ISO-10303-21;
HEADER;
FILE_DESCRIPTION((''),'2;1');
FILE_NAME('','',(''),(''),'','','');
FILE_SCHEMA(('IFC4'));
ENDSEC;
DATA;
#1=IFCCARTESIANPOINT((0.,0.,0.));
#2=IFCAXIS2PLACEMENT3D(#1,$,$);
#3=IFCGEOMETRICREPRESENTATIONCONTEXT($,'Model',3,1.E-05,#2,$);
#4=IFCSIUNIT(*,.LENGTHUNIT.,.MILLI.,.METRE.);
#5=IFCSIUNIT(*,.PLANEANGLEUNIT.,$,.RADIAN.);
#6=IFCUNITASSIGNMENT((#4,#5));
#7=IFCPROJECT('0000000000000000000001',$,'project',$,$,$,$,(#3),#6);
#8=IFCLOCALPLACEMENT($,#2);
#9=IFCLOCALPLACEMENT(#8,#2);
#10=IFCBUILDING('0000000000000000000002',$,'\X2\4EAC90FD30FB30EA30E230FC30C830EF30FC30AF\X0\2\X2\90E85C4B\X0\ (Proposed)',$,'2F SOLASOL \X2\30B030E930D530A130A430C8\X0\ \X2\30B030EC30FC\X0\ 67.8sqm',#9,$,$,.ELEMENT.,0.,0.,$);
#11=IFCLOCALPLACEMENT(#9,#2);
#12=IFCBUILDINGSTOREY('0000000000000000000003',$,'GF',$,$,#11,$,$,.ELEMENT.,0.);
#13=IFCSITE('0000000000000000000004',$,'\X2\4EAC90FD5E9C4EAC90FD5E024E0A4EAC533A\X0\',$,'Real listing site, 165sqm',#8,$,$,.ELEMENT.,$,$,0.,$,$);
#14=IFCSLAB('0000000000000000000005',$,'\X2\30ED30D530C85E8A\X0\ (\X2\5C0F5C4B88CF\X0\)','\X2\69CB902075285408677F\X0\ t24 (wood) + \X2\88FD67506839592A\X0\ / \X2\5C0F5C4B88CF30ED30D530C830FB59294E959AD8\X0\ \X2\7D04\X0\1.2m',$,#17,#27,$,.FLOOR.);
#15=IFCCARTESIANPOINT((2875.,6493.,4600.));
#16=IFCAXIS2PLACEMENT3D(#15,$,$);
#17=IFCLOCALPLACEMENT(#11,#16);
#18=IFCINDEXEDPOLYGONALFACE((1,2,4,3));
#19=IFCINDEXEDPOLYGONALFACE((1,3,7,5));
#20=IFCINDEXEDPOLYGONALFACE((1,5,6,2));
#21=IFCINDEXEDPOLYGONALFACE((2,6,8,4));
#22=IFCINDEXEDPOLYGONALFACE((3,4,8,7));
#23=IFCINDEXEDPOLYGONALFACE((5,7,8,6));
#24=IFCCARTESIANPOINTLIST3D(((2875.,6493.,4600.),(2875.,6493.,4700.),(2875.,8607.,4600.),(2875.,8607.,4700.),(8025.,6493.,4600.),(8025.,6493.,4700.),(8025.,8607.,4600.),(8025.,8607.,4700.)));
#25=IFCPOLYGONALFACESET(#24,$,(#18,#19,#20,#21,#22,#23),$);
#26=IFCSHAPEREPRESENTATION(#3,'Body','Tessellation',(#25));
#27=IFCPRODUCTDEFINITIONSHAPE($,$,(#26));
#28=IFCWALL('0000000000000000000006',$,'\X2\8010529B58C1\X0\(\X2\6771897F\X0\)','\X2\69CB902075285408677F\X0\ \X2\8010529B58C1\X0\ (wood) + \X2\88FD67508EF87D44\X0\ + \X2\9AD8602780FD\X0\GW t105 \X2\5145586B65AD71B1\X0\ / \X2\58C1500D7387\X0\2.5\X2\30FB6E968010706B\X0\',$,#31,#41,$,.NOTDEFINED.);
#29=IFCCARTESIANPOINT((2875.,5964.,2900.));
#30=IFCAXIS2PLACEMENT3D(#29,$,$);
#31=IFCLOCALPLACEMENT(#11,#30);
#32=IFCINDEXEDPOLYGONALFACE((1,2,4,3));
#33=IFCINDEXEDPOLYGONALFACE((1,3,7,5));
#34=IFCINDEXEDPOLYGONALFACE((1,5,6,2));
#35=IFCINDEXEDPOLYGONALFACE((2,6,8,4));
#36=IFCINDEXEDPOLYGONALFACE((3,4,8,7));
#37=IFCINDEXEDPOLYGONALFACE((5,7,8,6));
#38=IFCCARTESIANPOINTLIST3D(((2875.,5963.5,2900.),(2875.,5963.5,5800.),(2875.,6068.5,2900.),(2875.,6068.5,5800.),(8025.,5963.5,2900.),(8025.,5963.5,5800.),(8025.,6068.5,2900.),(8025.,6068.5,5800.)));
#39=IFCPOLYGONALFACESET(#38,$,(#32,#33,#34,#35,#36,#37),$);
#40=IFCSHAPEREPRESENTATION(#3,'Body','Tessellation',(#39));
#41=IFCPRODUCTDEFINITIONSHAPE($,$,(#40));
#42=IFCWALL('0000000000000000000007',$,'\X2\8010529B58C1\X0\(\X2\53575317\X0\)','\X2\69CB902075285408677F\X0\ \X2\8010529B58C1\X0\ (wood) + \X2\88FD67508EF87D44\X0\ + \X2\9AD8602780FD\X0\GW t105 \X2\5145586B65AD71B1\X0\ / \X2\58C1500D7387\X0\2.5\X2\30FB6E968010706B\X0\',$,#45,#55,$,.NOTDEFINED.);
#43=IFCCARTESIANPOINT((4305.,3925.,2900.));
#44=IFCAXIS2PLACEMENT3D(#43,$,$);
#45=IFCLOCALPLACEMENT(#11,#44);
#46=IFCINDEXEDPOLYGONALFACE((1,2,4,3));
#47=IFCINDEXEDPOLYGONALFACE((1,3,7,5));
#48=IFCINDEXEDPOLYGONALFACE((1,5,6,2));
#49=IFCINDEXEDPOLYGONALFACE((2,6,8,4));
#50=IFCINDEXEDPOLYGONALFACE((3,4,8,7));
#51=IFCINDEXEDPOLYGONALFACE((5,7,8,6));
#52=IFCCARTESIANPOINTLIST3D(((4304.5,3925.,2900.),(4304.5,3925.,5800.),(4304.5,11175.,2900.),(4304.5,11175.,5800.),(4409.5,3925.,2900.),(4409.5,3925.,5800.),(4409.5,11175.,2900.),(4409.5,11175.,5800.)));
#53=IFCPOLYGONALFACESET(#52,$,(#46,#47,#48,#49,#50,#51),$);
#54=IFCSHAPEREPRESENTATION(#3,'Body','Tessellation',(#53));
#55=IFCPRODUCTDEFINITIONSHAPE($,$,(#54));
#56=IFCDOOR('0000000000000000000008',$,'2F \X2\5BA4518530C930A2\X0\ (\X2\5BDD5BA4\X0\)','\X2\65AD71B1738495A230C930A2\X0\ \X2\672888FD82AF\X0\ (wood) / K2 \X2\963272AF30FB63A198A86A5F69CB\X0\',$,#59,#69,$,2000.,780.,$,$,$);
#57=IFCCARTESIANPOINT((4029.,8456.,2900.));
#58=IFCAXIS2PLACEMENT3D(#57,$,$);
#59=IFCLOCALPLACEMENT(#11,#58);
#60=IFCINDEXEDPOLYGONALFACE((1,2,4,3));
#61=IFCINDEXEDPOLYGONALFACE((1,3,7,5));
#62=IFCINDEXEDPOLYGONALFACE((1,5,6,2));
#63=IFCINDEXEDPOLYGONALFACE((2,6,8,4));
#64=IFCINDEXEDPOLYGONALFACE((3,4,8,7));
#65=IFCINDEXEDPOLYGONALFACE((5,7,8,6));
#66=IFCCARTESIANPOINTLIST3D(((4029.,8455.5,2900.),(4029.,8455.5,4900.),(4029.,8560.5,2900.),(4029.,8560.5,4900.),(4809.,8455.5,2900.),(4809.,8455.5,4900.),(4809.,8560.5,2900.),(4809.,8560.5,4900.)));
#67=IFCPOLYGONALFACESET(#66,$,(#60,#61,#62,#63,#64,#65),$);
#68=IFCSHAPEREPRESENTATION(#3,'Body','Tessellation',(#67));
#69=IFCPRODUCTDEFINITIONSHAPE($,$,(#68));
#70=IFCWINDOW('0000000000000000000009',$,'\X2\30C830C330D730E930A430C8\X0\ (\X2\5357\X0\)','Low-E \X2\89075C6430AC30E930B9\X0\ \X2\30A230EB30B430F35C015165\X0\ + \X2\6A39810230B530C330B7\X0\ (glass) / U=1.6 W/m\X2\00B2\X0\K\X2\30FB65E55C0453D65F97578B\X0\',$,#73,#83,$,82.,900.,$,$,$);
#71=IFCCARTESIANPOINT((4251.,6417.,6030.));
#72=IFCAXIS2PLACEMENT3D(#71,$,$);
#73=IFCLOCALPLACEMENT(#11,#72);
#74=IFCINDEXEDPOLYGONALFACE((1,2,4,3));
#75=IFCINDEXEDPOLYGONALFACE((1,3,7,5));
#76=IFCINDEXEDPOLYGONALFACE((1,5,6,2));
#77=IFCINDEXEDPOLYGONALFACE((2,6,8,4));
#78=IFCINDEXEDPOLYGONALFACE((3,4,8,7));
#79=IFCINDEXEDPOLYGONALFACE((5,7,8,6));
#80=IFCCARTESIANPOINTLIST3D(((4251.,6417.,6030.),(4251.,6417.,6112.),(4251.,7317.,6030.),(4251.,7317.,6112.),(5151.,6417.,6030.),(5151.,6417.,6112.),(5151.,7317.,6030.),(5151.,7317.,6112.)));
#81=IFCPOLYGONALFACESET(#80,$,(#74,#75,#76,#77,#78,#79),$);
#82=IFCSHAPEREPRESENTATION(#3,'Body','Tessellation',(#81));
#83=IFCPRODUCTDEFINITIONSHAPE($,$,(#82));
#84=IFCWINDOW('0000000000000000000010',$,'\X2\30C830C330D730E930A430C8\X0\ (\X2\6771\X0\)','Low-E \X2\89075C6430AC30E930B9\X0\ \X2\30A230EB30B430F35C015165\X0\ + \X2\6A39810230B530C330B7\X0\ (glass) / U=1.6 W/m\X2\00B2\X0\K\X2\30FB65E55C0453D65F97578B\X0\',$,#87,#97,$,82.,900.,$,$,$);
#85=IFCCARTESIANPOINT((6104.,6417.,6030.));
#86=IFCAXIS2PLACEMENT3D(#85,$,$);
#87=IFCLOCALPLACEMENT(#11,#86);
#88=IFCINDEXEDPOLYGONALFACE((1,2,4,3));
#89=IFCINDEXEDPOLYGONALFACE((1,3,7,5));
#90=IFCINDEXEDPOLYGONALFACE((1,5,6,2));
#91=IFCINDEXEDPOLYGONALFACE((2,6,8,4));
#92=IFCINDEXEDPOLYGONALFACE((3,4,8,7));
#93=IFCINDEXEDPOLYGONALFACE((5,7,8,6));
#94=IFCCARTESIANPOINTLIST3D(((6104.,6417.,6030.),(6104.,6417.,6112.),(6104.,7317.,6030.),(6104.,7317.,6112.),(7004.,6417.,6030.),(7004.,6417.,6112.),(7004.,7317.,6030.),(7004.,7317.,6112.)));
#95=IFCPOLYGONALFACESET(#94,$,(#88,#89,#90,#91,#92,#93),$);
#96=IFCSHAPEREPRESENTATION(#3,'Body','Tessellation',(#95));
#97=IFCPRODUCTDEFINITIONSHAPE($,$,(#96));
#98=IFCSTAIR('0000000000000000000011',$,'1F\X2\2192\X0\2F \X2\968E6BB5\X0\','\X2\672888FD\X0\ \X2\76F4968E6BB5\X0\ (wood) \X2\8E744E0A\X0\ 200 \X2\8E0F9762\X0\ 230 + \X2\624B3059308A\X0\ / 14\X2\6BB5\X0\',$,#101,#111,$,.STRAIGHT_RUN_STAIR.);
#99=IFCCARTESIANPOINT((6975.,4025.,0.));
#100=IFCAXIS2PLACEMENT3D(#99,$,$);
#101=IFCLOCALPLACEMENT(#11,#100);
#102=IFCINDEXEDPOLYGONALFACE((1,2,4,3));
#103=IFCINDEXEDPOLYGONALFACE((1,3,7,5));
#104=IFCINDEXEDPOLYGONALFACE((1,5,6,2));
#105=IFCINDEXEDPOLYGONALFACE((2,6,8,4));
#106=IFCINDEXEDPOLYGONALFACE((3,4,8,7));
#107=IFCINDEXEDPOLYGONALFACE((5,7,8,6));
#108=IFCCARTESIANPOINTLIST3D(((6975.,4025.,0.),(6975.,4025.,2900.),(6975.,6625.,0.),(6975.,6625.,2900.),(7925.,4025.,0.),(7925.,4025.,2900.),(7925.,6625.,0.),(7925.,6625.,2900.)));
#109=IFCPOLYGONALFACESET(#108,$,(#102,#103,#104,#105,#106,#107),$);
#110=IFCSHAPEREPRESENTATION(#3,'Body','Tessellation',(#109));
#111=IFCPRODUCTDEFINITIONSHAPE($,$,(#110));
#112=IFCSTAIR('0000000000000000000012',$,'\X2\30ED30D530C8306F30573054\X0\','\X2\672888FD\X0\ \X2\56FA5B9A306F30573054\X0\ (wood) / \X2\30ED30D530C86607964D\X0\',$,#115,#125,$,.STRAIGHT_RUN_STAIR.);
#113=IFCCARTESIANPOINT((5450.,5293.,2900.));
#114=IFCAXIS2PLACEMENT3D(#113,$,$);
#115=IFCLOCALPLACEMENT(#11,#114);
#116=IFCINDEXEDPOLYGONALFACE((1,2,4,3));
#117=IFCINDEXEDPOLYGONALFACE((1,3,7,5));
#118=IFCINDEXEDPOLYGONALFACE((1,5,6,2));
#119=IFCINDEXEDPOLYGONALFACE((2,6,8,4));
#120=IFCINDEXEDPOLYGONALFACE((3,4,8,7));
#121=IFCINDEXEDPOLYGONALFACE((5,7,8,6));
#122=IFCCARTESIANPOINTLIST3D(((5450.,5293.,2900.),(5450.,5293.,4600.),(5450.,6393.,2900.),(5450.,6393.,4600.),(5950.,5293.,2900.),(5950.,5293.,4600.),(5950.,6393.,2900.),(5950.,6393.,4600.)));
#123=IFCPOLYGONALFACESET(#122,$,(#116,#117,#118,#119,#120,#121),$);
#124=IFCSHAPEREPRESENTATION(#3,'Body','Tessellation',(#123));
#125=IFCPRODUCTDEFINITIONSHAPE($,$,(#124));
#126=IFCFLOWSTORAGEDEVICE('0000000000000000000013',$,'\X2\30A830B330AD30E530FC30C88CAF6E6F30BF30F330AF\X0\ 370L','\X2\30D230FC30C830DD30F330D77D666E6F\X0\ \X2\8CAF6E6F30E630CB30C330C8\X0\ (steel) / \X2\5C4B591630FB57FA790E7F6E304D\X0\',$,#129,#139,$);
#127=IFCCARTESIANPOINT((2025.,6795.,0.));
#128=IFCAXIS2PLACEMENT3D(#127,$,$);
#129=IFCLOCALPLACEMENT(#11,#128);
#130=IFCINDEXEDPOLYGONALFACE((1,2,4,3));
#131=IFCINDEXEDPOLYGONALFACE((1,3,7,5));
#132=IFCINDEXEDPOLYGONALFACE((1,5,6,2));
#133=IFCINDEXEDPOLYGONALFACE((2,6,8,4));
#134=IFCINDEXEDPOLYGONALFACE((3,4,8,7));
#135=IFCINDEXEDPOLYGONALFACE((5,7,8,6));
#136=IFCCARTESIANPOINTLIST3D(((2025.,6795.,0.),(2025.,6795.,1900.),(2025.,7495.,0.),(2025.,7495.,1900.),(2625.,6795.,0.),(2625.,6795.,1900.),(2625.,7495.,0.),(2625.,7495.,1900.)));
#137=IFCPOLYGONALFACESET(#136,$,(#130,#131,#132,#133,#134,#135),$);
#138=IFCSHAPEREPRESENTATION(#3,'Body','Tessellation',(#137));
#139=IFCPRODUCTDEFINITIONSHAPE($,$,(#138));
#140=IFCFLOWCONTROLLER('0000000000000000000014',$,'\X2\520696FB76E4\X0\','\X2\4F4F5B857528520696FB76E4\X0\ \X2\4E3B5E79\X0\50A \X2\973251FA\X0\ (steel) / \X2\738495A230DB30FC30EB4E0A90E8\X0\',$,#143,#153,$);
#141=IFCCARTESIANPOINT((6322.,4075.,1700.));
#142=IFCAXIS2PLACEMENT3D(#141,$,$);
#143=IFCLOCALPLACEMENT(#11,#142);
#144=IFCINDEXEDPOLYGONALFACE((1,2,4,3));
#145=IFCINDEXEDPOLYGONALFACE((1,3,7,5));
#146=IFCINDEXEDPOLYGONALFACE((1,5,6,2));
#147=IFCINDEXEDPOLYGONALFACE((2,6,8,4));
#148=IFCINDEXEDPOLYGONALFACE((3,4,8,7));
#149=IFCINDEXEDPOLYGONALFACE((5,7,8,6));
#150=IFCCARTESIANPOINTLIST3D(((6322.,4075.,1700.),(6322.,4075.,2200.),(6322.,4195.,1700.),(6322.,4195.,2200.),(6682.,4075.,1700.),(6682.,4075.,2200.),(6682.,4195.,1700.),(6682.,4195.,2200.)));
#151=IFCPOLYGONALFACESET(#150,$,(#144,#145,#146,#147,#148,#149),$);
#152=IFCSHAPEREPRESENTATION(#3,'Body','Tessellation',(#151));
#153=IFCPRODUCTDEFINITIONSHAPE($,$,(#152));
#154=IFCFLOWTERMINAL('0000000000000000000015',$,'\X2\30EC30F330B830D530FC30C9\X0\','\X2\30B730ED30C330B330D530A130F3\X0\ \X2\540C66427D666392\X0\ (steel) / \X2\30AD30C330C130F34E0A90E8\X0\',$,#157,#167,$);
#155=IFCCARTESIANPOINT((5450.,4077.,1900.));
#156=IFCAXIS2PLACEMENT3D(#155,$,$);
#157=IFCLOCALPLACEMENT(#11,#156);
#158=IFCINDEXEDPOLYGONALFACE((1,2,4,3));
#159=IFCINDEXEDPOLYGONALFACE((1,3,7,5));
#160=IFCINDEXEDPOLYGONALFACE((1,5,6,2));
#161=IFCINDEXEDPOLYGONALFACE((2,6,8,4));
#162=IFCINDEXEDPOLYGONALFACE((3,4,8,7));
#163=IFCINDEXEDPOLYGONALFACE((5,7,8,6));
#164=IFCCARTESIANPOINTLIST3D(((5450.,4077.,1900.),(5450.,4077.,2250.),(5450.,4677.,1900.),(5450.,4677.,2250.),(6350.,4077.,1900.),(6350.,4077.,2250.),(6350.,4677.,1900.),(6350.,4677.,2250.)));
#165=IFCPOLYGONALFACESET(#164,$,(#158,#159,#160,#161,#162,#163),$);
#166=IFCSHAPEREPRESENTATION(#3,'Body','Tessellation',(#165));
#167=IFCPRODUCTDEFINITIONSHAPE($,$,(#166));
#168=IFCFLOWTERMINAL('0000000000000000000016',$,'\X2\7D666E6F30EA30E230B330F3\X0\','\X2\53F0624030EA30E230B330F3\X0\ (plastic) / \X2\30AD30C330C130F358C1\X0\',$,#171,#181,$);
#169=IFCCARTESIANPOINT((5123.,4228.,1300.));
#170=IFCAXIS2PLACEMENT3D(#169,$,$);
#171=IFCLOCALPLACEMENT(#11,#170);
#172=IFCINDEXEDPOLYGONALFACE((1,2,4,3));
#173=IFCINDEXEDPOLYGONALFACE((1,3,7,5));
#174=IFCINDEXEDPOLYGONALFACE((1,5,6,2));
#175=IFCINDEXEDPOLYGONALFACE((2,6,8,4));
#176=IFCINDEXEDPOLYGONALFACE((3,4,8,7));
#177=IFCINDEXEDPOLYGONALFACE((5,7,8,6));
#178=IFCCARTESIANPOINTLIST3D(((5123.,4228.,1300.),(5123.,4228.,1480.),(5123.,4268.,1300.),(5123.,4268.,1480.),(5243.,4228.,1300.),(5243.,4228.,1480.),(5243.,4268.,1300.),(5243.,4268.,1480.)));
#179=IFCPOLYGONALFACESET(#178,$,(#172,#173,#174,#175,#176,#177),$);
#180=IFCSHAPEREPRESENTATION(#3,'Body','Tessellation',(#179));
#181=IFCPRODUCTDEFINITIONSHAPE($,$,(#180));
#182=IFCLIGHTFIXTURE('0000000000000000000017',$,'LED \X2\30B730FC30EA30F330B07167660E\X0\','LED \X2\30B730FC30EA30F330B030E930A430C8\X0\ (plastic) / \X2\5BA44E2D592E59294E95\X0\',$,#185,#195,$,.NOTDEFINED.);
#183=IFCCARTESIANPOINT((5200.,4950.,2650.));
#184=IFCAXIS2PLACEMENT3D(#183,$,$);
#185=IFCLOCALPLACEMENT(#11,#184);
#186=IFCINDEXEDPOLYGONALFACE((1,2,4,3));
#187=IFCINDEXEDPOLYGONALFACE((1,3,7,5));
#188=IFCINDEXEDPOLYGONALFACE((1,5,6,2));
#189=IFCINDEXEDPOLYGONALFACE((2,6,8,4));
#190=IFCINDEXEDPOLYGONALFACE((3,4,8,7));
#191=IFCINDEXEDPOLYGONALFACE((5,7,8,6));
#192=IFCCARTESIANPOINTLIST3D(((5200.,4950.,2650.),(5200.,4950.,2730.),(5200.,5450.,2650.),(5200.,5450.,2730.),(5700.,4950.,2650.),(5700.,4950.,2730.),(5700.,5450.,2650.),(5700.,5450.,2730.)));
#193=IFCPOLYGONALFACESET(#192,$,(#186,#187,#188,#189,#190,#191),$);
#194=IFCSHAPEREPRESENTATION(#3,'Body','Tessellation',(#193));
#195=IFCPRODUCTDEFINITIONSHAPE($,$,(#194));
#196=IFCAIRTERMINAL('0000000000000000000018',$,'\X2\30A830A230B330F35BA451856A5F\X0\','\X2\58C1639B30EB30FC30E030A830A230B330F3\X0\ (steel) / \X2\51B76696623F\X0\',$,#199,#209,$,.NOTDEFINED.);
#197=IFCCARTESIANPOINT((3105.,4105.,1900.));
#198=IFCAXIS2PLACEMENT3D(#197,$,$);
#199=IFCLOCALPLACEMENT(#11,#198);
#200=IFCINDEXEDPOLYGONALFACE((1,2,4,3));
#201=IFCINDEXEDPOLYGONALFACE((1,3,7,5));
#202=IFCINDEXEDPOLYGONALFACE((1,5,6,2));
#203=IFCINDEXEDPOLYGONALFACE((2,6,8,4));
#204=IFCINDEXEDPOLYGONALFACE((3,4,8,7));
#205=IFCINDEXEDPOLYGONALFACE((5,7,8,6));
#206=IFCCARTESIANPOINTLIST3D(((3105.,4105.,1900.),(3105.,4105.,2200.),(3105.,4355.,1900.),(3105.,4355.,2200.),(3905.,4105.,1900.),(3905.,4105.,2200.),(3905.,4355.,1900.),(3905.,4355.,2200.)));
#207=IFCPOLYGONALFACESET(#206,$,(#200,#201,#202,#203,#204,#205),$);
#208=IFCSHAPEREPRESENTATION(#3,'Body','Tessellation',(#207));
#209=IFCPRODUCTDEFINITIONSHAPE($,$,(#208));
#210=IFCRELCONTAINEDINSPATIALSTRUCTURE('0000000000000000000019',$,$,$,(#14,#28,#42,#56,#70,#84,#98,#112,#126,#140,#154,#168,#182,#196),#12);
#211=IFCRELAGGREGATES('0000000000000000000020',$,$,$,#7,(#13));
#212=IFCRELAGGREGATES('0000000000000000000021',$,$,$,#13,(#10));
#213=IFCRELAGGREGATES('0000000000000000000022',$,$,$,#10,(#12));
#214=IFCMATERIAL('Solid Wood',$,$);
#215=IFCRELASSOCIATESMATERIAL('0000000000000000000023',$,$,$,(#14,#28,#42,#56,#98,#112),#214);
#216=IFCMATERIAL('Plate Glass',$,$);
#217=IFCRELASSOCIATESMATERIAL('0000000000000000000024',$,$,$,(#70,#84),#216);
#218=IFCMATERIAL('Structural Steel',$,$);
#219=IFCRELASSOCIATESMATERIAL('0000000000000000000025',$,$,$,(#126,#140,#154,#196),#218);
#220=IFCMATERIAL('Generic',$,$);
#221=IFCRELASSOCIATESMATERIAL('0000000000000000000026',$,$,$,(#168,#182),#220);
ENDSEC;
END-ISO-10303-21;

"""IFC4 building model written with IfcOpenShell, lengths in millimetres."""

from ifc_helpers import new_model, si_unit, frame, frame_2d, origin, place, context, project, spatial, rectangle, extrude, material, element, fill, save


model = new_model("IFC4")

# Units and contexts
model_context = context("Model", 3, precision=1e-05, world=origin())
ifc_project = project(units=[si_unit("LENGTHUNIT", "METRE", prefix="MILLI"), si_unit("PLANEANGLEUNIT", "RADIAN")], contexts=[model_context])

# Site, building, storey
site_placement = place(None, origin())
site = spatial("IfcSite", under=ifc_project, at=site_placement, Name="京都府京都市上京区", ObjectType="Real listing site, 165sqm", CompositionType="ELEMENT", RefElevation=0.0)
building_placement = place(site_placement, origin())
building = spatial("IfcBuilding", under=site, at=building_placement, Name="京都・リモートワーク2部屋 (Proposed)", ObjectType="2F SOLASOL グラファイト グレー 67.8sqm", CompositionType="ELEMENT", ElevationOfRefHeight=0.0, ElevationOfTerrain=0.0)
storey_placement = place(building_placement, origin())
storey = spatial("IfcBuildingStorey", under=building, at=storey_placement, Name="GF", CompositionType="ELEMENT", Elevation=0.0)

# Shared definitions
ifc_material_1 = material(Name="Solid Wood")

# Slab
slab_placement = place(storey_placement, frame((2875.0, 6493.0, 4600.0)))
element("IfcSlab", 1, at=slab_placement, inside=storey, material=ifc_material_1, Name="ロフト床 (小屋裏)", Description="構造用合板 t24 (wood) + 製材根太 / 小屋裏ロフト・天井高 約1.2m", PredefinedType="FLOOR", context=model_context, shape_type="SweptSolid", body=[
    extrude(rectangle(XDim=5150.0, YDim=2114.0, at=frame_2d((2575.0, 1057.0))), frame((2875.0, 6493.0, 4600.0)), (0.0, 0.0, 1.0), 100.0),
])

# Wall
wall_1_placement = place(storey_placement, frame((2875.0, 5964.0, 2900.0)))
element("IfcWall", 2, at=wall_1_placement, inside=storey, material=ifc_material_1, Name="耐力壁(東西)", Description="構造用合板 耐力壁 (wood) + 製材軸組 + 高性能GW t105 充填断熱 / 壁倍率2.5・準耐火", PredefinedType="NOTDEFINED", context=model_context, shape_type="SweptSolid", body=[
    extrude(rectangle(XDim=5150.0, YDim=105.0, at=frame_2d((2575.0, 52.0))), frame((2875.0, 5964.0, 2900.0)), (0.0, 0.0, 1.0), 2900.0),
])

# Wall, opening, door
wall_2_placement = place(storey_placement, frame((4305.0, 3925.0, 2900.0)))
wall_2 = element("IfcWall", 3, at=wall_2_placement, inside=storey, material=ifc_material_1, Name="耐力壁(南北)", Description="構造用合板 耐力壁 (wood) + 製材軸組 + 高性能GW t105 充填断熱 / 壁倍率2.5・準耐火", PredefinedType="NOTDEFINED", context=model_context, shape_type="SweptSolid", body=[
    extrude(rectangle(XDim=105.0, YDim=7250.0, at=frame_2d((52.0, 3625.0))), frame((4305.0, 3925.0, 2900.0)), (0.0, 0.0, 1.0), 2900.0),
])
opening_placement = place(storey_placement, frame((4029.0, 8456.0, 2900.0)))
opening = element("IfcOpeningElement", 4, at=opening_placement, cuts=wall_2, PredefinedType="NOTDEFINED", context=model_context, shape_type="SweptSolid", body=[
    extrude(rectangle(XDim=780.0, YDim=105.0, at=frame_2d((390.0, 52.0))), frame((4029.0, 8456.0, 2900.0)), (0.0, 0.0, 1.0), 2000.0),
])
door_placement = place(storey_placement, frame((4029.0, 8456.0, 2900.0)))
door = element("IfcDoor", 5, at=door_placement, inside=storey, material=ifc_material_1, Name="2F 室内ドア (寝室)", Description="断熱玄関ドア 木製芯 (wood) / K2 防犯・採風機構", OverallHeight=2000.0, OverallWidth=780.0, context=model_context, shape_type="SweptSolid", body=[
    extrude(rectangle(XDim=780.0, YDim=105.0, at=frame_2d((390.0, 52.0))), frame((4029.0, 8456.0, 2900.0)), (0.0, 0.0, 1.0), 2000.0),
])
fill(opening, door)

# Windows
ifc_material_2 = material(Name="Plate Glass")
window_1_placement = place(storey_placement, frame((4251.0, 6417.0, 6030.0)))
element("IfcWindow", 6, at=window_1_placement, inside=storey, material=ifc_material_2, Name="トップライト (南)", Description="Low-E 複層ガラス アルゴン封入 + 樹脂サッシ (glass) / U=1.6 W/m²K・日射取得型", OverallHeight=82.0, OverallWidth=900.0, context=model_context, shape_type="SweptSolid", body=[
    extrude(rectangle(XDim=900.0, YDim=900.0, at=frame_2d((450.0, 450.0))), frame((4251.0, 6417.0, 6030.0)), (0.0, 0.0, 1.0), 82.0),
])
window_2_placement = place(storey_placement, frame((6104.0, 6417.0, 6030.0)))
element("IfcWindow", 7, at=window_2_placement, inside=storey, material=ifc_material_2, Name="トップライト (東)", Description="Low-E 複層ガラス アルゴン封入 + 樹脂サッシ (glass) / U=1.6 W/m²K・日射取得型", OverallHeight=82.0, OverallWidth=900.0, context=model_context, shape_type="SweptSolid", body=[
    extrude(rectangle(XDim=900.0, YDim=900.0, at=frame_2d((450.0, 450.0))), frame((6104.0, 6417.0, 6030.0)), (0.0, 0.0, 1.0), 82.0),
])

# Stairs
stair_1_placement = place(storey_placement, frame((6975.0, 4025.0, 0.0)))
element("IfcStair", 8, at=stair_1_placement, inside=storey, material=ifc_material_1, Name="1F→2F 階段", Description="木製 直階段 (wood) 蹴上 200 踏面 230 + 手すり / 14段", PredefinedType="STRAIGHT_RUN_STAIR", context=model_context, shape_type="SweptSolid", body=[
    extrude(rectangle(XDim=950.0, YDim=2600.0, at=frame_2d((475.0, 1300.0))), frame((6975.0, 4025.0, 0.0)), (0.0, 0.0, 1.0), 2900.0),
])
stair_2_placement = place(storey_placement, frame((5450.0, 5293.0, 2900.0)))
element("IfcStair", 9, at=stair_2_placement, inside=storey, material=ifc_material_1, Name="ロフトはしご", Description="木製 固定はしご (wood) / ロフト昇降", PredefinedType="STRAIGHT_RUN_STAIR", context=model_context, shape_type="SweptSolid", body=[
    extrude(rectangle(XDim=500.0, YDim=1100.0, at=frame_2d((250.0, 550.0))), frame((5450.0, 5293.0, 2900.0)), (0.0, 0.0, 1.0), 1700.0),
])

# Flow storage device
ifc_material_3 = material(Name="Structural Steel")
flow_storage_device_placement = place(storey_placement, frame((2025.0, 6795.0, 0.0)))
element("IfcFlowStorageDevice", 10, at=flow_storage_device_placement, inside=storey, material=ifc_material_3, Name="エコキュート貯湯タンク 370L", Description="ヒートポンプ給湯 貯湯ユニット (steel) / 屋外・基礎置き", context=model_context, shape_type="SweptSolid", body=[
    extrude(rectangle(XDim=600.0, YDim=700.0, at=frame_2d((300.0, 350.0))), frame((2025.0, 6795.0, 0.0)), (0.0, 0.0, 1.0), 1900.0),
])

# Flow controller
flow_controller_placement = place(storey_placement, frame((6322.0, 4075.0, 1700.0)))
element("IfcFlowController", 11, at=flow_controller_placement, inside=storey, material=ifc_material_3, Name="分電盤", Description="住宅用分電盤 主幹50A 露出 (steel) / 玄関ホール上部", context=model_context, shape_type="SweptSolid", body=[
    extrude(rectangle(XDim=360.0, YDim=120.0, at=frame_2d((180.0, 60.0))), frame((6322.0, 4075.0, 1700.0)), (0.0, 0.0, 1.0), 500.0),
])

# Flow terminals
flow_terminal_1_placement = place(storey_placement, frame((5450.0, 4077.0, 1900.0)))
element("IfcFlowTerminal", 12, at=flow_terminal_1_placement, inside=storey, material=ifc_material_3, Name="レンジフード", Description="シロッコファン 同時給排 (steel) / キッチン上部", context=model_context, shape_type="SweptSolid", body=[
    extrude(rectangle(XDim=900.0, YDim=600.0, at=frame_2d((450.0, 300.0))), frame((5450.0, 4077.0, 1900.0)), (0.0, 0.0, 1.0), 350.0),
])
ifc_material_4 = material(Name="Generic")
flow_terminal_2_placement = place(storey_placement, frame((5123.0, 4228.0, 1300.0)))
element("IfcFlowTerminal", 13, at=flow_terminal_2_placement, inside=storey, material=ifc_material_4, Name="給湯リモコン", Description="台所リモコン (plastic) / キッチン壁", context=model_context, shape_type="SweptSolid", body=[
    extrude(rectangle(XDim=120.0, YDim=40.0, at=frame_2d((60.0, 20.0))), frame((5123.0, 4228.0, 1300.0)), (0.0, 0.0, 1.0), 180.0),
])

# Light fixture
light_fixture_1_placement = place(storey_placement, frame((5200.0, 4950.0, 2650.0)))
element("IfcLightFixture", 14, at=light_fixture_1_placement, inside=storey, material=ifc_material_4, Name="LED シーリング照明", Description="LED シーリングライト (plastic) / 室中央天井", PredefinedType="NOTDEFINED", context=model_context, shape_type="SweptSolid", body=[
    extrude(rectangle(XDim=500.0, YDim=500.0, at=frame_2d((250.0, 250.0))), frame((5200.0, 4950.0, 2650.0)), (0.0, 0.0, 1.0), 80.0),
])

# Air terminal
air_terminal_1_placement = place(storey_placement, frame((3105.0, 4105.0, 1900.0)))
element("IfcAirTerminal", 15, at=air_terminal_1_placement, inside=storey, material=ifc_material_3, Name="エアコン室内機", Description="壁掛ルームエアコン (steel) / 冷暖房", PredefinedType="NOTDEFINED", context=model_context, shape_type="SweptSolid", body=[
    extrude(rectangle(XDim=800.0, YDim=250.0, at=frame_2d((400.0, 125.0))), frame((3105.0, 4105.0, 1900.0)), (0.0, 0.0, 1.0), 300.0),
])

save(model, "model.ifc")
